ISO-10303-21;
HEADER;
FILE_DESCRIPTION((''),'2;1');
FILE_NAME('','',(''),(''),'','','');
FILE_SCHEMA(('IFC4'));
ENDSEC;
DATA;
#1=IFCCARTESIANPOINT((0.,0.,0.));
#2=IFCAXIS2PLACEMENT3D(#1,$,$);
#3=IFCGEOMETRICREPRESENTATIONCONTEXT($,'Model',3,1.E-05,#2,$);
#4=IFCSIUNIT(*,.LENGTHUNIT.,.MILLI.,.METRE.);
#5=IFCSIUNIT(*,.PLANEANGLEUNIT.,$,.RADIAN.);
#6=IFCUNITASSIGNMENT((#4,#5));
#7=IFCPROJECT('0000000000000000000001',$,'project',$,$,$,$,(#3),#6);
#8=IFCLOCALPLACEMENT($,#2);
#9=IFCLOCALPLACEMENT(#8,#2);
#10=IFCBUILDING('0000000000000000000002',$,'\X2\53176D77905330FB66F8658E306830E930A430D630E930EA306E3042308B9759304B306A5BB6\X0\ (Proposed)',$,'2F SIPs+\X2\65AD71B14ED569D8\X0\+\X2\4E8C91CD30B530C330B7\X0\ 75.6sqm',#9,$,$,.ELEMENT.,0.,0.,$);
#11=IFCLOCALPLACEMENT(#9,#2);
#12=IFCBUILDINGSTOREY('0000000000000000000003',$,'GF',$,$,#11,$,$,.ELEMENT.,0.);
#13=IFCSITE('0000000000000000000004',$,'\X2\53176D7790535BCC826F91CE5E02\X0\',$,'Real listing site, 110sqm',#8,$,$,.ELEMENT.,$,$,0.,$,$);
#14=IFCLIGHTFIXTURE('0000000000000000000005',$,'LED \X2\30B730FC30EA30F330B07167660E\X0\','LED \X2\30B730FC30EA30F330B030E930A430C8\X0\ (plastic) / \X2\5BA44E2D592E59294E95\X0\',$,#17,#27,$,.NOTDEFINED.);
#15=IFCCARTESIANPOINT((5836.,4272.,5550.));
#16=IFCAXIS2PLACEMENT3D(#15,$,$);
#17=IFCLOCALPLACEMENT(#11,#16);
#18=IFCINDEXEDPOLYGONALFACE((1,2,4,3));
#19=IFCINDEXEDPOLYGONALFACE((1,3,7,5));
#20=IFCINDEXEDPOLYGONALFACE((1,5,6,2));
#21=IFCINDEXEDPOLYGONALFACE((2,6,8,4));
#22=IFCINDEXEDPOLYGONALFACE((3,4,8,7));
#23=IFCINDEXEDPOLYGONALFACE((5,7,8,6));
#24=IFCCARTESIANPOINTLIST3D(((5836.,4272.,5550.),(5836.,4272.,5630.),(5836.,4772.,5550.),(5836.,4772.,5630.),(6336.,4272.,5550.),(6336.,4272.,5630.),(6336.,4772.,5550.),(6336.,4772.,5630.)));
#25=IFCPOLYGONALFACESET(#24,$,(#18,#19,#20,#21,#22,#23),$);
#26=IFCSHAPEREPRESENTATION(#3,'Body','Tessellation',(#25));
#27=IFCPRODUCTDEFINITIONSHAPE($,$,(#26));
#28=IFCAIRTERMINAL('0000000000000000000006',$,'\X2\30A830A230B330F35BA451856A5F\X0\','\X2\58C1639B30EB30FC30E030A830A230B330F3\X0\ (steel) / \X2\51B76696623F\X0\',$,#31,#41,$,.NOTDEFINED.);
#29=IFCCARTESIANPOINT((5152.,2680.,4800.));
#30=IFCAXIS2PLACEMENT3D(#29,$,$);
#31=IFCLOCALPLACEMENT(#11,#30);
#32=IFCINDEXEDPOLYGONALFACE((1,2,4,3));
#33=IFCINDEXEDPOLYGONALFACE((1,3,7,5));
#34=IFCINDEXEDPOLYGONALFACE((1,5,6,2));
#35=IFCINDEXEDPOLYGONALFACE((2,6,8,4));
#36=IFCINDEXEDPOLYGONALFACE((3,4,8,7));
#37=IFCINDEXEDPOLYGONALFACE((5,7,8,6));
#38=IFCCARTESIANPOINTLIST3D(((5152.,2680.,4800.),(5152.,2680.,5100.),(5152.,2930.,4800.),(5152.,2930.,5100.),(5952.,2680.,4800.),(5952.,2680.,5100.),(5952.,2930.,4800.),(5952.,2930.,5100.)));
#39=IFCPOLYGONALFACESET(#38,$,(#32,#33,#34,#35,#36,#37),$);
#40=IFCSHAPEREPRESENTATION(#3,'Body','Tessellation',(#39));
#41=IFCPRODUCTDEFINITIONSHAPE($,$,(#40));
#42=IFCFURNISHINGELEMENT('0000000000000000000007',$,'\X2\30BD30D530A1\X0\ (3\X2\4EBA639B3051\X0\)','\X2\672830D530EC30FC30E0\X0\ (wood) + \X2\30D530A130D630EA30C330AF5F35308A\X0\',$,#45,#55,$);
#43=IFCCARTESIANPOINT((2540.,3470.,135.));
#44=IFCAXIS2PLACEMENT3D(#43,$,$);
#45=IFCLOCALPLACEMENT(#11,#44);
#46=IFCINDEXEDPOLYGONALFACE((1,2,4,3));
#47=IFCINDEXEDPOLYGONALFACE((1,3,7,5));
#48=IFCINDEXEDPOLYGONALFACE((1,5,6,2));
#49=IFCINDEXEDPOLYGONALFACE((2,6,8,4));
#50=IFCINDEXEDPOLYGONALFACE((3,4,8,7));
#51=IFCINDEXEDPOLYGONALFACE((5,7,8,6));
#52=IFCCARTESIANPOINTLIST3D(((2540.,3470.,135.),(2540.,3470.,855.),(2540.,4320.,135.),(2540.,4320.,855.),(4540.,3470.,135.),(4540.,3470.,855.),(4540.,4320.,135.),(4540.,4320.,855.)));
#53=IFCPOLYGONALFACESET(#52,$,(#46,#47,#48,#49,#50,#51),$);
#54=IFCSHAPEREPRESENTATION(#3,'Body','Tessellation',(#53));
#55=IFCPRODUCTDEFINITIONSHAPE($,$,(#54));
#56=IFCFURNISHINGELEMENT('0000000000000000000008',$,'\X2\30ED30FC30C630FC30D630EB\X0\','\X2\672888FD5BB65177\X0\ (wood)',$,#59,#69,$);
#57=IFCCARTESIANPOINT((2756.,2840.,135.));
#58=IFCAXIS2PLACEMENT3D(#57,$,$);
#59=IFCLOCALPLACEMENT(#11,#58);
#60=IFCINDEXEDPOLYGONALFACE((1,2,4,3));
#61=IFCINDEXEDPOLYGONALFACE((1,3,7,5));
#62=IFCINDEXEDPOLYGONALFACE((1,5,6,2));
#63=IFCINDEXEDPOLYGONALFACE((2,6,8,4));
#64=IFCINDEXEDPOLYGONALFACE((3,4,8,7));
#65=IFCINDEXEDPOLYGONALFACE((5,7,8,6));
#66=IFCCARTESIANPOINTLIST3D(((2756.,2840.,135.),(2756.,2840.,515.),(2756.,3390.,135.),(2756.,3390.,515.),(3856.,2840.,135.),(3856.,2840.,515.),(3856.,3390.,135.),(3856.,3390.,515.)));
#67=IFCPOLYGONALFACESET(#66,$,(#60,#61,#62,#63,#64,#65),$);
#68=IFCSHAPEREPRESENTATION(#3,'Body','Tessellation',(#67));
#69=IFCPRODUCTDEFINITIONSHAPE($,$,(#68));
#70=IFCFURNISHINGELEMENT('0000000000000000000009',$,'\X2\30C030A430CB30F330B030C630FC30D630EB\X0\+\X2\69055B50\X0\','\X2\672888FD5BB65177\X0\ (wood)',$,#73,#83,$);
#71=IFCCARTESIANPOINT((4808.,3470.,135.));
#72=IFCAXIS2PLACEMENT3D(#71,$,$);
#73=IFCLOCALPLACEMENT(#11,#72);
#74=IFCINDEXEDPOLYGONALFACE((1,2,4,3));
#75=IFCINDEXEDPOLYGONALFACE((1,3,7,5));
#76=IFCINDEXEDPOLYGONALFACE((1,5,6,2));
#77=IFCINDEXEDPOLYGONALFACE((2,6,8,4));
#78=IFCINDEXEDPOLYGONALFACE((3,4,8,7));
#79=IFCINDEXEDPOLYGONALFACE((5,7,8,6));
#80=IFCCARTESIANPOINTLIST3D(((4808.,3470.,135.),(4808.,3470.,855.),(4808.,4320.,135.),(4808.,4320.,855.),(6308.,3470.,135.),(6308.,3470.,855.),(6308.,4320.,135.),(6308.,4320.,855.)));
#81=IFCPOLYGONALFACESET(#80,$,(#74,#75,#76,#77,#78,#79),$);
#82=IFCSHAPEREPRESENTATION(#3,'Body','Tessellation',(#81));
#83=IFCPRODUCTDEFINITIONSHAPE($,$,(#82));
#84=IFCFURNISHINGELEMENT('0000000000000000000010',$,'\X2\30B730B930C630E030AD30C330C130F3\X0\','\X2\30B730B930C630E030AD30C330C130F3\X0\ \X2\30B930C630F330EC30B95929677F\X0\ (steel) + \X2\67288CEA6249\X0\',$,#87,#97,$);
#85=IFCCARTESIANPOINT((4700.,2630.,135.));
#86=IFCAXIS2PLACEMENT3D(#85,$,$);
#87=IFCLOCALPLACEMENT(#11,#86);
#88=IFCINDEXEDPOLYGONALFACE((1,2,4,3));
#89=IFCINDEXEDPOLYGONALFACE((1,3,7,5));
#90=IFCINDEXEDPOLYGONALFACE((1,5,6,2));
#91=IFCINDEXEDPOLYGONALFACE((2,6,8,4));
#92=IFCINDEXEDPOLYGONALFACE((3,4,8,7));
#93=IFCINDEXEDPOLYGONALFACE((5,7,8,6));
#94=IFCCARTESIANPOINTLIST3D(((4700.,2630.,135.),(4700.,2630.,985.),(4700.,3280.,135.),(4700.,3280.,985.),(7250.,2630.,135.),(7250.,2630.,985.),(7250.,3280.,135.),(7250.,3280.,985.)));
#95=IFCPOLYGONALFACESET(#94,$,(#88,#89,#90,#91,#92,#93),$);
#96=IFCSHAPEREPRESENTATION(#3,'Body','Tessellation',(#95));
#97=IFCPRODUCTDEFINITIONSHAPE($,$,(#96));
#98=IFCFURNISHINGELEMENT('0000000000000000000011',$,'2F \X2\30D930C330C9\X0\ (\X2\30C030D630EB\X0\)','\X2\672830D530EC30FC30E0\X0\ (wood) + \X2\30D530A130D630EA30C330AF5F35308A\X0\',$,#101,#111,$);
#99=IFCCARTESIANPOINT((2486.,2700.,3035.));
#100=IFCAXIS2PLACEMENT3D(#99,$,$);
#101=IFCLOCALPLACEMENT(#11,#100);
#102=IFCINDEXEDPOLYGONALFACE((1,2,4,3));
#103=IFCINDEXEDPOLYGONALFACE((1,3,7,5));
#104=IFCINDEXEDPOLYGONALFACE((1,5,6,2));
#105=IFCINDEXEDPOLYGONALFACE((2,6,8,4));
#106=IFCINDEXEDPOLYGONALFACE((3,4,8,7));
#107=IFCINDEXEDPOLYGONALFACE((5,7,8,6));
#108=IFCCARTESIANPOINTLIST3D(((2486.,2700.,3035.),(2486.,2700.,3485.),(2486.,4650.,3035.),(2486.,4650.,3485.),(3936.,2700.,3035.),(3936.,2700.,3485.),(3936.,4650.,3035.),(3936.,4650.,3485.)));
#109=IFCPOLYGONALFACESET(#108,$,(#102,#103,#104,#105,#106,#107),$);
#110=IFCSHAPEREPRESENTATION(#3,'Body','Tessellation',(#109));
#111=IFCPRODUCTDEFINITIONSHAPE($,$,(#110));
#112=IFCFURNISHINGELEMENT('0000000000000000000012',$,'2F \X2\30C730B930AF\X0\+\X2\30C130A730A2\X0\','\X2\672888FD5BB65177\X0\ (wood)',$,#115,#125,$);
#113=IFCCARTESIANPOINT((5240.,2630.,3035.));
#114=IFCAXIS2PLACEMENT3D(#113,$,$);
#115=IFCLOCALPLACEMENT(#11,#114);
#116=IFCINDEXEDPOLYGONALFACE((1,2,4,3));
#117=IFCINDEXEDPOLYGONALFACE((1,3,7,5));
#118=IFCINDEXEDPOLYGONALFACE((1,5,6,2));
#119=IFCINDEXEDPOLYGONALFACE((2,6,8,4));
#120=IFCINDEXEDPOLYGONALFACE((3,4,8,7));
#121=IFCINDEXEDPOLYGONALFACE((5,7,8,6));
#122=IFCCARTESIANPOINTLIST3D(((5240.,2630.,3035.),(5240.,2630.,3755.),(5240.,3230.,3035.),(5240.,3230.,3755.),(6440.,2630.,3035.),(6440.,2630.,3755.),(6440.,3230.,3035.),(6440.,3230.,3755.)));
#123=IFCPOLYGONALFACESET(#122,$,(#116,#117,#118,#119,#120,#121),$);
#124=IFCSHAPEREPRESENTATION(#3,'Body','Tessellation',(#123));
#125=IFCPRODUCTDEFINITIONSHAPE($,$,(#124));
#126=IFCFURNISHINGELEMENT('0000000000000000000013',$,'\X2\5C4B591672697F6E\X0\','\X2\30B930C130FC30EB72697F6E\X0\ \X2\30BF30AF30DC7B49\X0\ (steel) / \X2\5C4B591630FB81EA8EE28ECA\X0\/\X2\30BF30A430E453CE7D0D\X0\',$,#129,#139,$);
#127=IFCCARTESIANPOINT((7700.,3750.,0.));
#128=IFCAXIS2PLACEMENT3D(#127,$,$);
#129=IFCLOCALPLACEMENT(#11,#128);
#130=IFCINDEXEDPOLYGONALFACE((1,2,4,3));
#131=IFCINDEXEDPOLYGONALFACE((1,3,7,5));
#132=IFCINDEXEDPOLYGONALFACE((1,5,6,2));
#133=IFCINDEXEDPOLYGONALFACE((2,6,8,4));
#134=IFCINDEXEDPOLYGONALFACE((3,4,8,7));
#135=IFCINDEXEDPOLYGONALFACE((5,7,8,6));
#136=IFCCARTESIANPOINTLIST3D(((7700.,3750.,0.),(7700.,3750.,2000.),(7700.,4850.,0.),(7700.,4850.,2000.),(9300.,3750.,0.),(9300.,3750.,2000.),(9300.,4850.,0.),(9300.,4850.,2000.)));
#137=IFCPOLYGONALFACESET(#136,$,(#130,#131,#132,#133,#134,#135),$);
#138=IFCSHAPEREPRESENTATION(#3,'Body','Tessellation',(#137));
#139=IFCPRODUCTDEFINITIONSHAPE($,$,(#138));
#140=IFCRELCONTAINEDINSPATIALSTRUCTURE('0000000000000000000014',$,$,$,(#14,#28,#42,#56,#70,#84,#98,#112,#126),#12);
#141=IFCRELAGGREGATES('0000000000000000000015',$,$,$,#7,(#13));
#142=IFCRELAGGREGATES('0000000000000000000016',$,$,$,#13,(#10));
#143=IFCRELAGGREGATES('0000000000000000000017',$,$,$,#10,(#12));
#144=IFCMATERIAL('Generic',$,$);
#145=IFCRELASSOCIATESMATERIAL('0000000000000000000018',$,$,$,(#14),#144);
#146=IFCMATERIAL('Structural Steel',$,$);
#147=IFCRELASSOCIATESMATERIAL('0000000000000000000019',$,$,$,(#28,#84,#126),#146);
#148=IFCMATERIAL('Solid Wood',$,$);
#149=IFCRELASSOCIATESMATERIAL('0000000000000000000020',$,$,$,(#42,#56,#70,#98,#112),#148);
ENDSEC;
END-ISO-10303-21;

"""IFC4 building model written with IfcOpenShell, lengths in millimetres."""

from ifc_helpers import new_model, si_unit, frame, frame_2d, origin, place, context, project, spatial, rectangle, extrude, material, element, save


model = new_model("IFC4")

# Units and contexts
model_context = context("Model", 3, precision=1e-05, world=origin())
ifc_project = project(units=[si_unit("LENGTHUNIT", "METRE", prefix="MILLI"), si_unit("PLANEANGLEUNIT", "RADIAN")], contexts=[model_context])

# Site, building, storey
site_placement = place(None, origin())
site = spatial("IfcSite", under=ifc_project, at=site_placement, Name="北海道富良野市", ObjectType="Real listing site, 110sqm", CompositionType="ELEMENT", RefElevation=0.0)
building_placement = place(site_placement, origin())
building = spatial("IfcBuilding", under=site, at=building_placement, Name="北海道・書斎とライブラリのある静かな家 (Proposed)", ObjectType="2F SIPs+断熱仕様+二重サッシ 75.6sqm", CompositionType="ELEMENT", ElevationOfRefHeight=0.0, ElevationOfTerrain=0.0)
storey_placement = place(building_placement, origin())
storey = spatial("IfcBuildingStorey", under=building, at=storey_placement, Name="GF", CompositionType="ELEMENT", Elevation=0.0)

# Shared definitions
ifc_material_1 = material(Name="Solid Wood")

# Shared definitions
ifc_material_2 = material(Name="Generic")

# Shared definitions
ifc_material_3 = material(Name="Structural Steel")

# Light fixture
light_fixture_placement = place(storey_placement, frame((5836.0, 4272.0, 5550.0)))
element("IfcLightFixture", 1, at=light_fixture_placement, inside=storey, material=ifc_material_2, Name="LED シーリング照明", Description="LED シーリングライト (plastic) / 室中央天井", PredefinedType="NOTDEFINED", context=model_context, shape_type="SweptSolid", body=[
    extrude(rectangle(XDim=500.0, YDim=500.0, at=frame_2d((250.0, 250.0))), frame((5836.0, 4272.0, 5550.0)), (0.0, 0.0, 1.0), 80.0),
])

# Air terminal
air_terminal_1_placement = place(storey_placement, frame((5152.0, 2680.0, 4800.0)))
element("IfcAirTerminal", 2, at=air_terminal_1_placement, inside=storey, material=ifc_material_3, Name="エアコン室内機", Description="壁掛ルームエアコン (steel) / 冷暖房", PredefinedType="NOTDEFINED", context=model_context, shape_type="SweptSolid", body=[
    extrude(rectangle(XDim=800.0, YDim=250.0, at=frame_2d((400.0, 125.0))), frame((5152.0, 2680.0, 4800.0)), (0.0, 0.0, 1.0), 300.0),
])

# Furnishing elements
furnishing_1_placement = place(storey_placement, frame((2540.0, 3470.0, 135.0)))
element("IfcFurnishingElement", 3, at=furnishing_1_placement, inside=storey, material=ifc_material_1, Name="ソファ (3人掛け)", Description="木フレーム (wood) + ファブリック張り", context=model_context, shape_type="SweptSolid", body=[
    extrude(rectangle(XDim=2000.0, YDim=850.0, at=frame_2d((1000.0, 425.0))), frame((2540.0, 3470.0, 135.0)), (0.0, 0.0, 1.0), 720.0),
])
furnishing_2_placement = place(storey_placement, frame((2756.0, 2840.0, 135.0)))
element("IfcFurnishingElement", 4, at=furnishing_2_placement, inside=storey, material=ifc_material_1, Name="ローテーブル", Description="木製家具 (wood)", context=model_context, shape_type="SweptSolid", body=[
    extrude(rectangle(XDim=1100.0, YDim=550.0, at=frame_2d((550.0, 275.0))), frame((2756.0, 2840.0, 135.0)), (0.0, 0.0, 1.0), 380.0),
])
furnishing_3_placement = place(storey_placement, frame((4808.0, 3470.0, 135.0)))
element("IfcFurnishingElement", 5, at=furnishing_3_placement, inside=storey, material=ifc_material_1, Name="ダイニングテーブル+椅子", Description="木製家具 (wood)", context=model_context, shape_type="SweptSolid", body=[
    extrude(rectangle(XDim=1500.0, YDim=850.0, at=frame_2d((750.0, 425.0))), frame((4808.0, 3470.0, 135.0)), (0.0, 0.0, 1.0), 720.0),
])
furnishing_4_placement = place(storey_placement, frame((4700.0, 2630.0, 135.0)))
element("IfcFurnishingElement", 6, at=furnishing_4_placement, inside=storey, material=ifc_material_3, Name="システムキッチン", Description="システムキッチン ステンレス天板 (steel) + 木質扉", context=model_context, shape_type="SweptSolid", body=[
    extrude(rectangle(XDim=2550.0, YDim=650.0, at=frame_2d((1275.0, 325.0))), frame((4700.0, 2630.0, 135.0)), (0.0, 0.0, 1.0), 850.0),
])
furnishing_5_placement = place(storey_placement, frame((2486.0, 2700.0, 3035.0)))
element("IfcFurnishingElement", 7, at=furnishing_5_placement, inside=storey, material=ifc_material_1, Name="2F ベッド (ダブル)", Description="木フレーム (wood) + ファブリック張り", context=model_context, shape_type="SweptSolid", body=[
    extrude(rectangle(XDim=1450.0, YDim=1950.0, at=frame_2d((725.0, 975.0))), frame((2486.0, 2700.0, 3035.0)), (0.0, 0.0, 1.0), 450.0),
])
furnishing_6_placement = place(storey_placement, frame((5240.0, 2630.0, 3035.0)))
element("IfcFurnishingElement", 8, at=furnishing_6_placement, inside=storey, material=ifc_material_1, Name="2F デスク+チェア", Description="木製家具 (wood)", context=model_context, shape_type="SweptSolid", body=[
    extrude(rectangle(XDim=1200.0, YDim=600.0, at=frame_2d((600.0, 300.0))), frame((5240.0, 2630.0, 3035.0)), (0.0, 0.0, 1.0), 720.0),
])
furnishing_7_placement = place(storey_placement, frame((7700.0, 3750.0, 0.0)))
element("IfcFurnishingElement", 9, at=furnishing_7_placement, inside=storey, material=ifc_material_3, Name="屋外物置", Description="スチール物置 タクボ等 (steel) / 屋外・自転車/タイヤ収納", context=model_context, shape_type="SweptSolid", body=[
    extrude(rectangle(XDim=1600.0, YDim=1100.0, at=frame_2d((800.0, 550.0))), frame((7700.0, 3750.0, 0.0)), (0.0, 0.0, 1.0), 2000.0),
])

save(model, "model.ifc")
